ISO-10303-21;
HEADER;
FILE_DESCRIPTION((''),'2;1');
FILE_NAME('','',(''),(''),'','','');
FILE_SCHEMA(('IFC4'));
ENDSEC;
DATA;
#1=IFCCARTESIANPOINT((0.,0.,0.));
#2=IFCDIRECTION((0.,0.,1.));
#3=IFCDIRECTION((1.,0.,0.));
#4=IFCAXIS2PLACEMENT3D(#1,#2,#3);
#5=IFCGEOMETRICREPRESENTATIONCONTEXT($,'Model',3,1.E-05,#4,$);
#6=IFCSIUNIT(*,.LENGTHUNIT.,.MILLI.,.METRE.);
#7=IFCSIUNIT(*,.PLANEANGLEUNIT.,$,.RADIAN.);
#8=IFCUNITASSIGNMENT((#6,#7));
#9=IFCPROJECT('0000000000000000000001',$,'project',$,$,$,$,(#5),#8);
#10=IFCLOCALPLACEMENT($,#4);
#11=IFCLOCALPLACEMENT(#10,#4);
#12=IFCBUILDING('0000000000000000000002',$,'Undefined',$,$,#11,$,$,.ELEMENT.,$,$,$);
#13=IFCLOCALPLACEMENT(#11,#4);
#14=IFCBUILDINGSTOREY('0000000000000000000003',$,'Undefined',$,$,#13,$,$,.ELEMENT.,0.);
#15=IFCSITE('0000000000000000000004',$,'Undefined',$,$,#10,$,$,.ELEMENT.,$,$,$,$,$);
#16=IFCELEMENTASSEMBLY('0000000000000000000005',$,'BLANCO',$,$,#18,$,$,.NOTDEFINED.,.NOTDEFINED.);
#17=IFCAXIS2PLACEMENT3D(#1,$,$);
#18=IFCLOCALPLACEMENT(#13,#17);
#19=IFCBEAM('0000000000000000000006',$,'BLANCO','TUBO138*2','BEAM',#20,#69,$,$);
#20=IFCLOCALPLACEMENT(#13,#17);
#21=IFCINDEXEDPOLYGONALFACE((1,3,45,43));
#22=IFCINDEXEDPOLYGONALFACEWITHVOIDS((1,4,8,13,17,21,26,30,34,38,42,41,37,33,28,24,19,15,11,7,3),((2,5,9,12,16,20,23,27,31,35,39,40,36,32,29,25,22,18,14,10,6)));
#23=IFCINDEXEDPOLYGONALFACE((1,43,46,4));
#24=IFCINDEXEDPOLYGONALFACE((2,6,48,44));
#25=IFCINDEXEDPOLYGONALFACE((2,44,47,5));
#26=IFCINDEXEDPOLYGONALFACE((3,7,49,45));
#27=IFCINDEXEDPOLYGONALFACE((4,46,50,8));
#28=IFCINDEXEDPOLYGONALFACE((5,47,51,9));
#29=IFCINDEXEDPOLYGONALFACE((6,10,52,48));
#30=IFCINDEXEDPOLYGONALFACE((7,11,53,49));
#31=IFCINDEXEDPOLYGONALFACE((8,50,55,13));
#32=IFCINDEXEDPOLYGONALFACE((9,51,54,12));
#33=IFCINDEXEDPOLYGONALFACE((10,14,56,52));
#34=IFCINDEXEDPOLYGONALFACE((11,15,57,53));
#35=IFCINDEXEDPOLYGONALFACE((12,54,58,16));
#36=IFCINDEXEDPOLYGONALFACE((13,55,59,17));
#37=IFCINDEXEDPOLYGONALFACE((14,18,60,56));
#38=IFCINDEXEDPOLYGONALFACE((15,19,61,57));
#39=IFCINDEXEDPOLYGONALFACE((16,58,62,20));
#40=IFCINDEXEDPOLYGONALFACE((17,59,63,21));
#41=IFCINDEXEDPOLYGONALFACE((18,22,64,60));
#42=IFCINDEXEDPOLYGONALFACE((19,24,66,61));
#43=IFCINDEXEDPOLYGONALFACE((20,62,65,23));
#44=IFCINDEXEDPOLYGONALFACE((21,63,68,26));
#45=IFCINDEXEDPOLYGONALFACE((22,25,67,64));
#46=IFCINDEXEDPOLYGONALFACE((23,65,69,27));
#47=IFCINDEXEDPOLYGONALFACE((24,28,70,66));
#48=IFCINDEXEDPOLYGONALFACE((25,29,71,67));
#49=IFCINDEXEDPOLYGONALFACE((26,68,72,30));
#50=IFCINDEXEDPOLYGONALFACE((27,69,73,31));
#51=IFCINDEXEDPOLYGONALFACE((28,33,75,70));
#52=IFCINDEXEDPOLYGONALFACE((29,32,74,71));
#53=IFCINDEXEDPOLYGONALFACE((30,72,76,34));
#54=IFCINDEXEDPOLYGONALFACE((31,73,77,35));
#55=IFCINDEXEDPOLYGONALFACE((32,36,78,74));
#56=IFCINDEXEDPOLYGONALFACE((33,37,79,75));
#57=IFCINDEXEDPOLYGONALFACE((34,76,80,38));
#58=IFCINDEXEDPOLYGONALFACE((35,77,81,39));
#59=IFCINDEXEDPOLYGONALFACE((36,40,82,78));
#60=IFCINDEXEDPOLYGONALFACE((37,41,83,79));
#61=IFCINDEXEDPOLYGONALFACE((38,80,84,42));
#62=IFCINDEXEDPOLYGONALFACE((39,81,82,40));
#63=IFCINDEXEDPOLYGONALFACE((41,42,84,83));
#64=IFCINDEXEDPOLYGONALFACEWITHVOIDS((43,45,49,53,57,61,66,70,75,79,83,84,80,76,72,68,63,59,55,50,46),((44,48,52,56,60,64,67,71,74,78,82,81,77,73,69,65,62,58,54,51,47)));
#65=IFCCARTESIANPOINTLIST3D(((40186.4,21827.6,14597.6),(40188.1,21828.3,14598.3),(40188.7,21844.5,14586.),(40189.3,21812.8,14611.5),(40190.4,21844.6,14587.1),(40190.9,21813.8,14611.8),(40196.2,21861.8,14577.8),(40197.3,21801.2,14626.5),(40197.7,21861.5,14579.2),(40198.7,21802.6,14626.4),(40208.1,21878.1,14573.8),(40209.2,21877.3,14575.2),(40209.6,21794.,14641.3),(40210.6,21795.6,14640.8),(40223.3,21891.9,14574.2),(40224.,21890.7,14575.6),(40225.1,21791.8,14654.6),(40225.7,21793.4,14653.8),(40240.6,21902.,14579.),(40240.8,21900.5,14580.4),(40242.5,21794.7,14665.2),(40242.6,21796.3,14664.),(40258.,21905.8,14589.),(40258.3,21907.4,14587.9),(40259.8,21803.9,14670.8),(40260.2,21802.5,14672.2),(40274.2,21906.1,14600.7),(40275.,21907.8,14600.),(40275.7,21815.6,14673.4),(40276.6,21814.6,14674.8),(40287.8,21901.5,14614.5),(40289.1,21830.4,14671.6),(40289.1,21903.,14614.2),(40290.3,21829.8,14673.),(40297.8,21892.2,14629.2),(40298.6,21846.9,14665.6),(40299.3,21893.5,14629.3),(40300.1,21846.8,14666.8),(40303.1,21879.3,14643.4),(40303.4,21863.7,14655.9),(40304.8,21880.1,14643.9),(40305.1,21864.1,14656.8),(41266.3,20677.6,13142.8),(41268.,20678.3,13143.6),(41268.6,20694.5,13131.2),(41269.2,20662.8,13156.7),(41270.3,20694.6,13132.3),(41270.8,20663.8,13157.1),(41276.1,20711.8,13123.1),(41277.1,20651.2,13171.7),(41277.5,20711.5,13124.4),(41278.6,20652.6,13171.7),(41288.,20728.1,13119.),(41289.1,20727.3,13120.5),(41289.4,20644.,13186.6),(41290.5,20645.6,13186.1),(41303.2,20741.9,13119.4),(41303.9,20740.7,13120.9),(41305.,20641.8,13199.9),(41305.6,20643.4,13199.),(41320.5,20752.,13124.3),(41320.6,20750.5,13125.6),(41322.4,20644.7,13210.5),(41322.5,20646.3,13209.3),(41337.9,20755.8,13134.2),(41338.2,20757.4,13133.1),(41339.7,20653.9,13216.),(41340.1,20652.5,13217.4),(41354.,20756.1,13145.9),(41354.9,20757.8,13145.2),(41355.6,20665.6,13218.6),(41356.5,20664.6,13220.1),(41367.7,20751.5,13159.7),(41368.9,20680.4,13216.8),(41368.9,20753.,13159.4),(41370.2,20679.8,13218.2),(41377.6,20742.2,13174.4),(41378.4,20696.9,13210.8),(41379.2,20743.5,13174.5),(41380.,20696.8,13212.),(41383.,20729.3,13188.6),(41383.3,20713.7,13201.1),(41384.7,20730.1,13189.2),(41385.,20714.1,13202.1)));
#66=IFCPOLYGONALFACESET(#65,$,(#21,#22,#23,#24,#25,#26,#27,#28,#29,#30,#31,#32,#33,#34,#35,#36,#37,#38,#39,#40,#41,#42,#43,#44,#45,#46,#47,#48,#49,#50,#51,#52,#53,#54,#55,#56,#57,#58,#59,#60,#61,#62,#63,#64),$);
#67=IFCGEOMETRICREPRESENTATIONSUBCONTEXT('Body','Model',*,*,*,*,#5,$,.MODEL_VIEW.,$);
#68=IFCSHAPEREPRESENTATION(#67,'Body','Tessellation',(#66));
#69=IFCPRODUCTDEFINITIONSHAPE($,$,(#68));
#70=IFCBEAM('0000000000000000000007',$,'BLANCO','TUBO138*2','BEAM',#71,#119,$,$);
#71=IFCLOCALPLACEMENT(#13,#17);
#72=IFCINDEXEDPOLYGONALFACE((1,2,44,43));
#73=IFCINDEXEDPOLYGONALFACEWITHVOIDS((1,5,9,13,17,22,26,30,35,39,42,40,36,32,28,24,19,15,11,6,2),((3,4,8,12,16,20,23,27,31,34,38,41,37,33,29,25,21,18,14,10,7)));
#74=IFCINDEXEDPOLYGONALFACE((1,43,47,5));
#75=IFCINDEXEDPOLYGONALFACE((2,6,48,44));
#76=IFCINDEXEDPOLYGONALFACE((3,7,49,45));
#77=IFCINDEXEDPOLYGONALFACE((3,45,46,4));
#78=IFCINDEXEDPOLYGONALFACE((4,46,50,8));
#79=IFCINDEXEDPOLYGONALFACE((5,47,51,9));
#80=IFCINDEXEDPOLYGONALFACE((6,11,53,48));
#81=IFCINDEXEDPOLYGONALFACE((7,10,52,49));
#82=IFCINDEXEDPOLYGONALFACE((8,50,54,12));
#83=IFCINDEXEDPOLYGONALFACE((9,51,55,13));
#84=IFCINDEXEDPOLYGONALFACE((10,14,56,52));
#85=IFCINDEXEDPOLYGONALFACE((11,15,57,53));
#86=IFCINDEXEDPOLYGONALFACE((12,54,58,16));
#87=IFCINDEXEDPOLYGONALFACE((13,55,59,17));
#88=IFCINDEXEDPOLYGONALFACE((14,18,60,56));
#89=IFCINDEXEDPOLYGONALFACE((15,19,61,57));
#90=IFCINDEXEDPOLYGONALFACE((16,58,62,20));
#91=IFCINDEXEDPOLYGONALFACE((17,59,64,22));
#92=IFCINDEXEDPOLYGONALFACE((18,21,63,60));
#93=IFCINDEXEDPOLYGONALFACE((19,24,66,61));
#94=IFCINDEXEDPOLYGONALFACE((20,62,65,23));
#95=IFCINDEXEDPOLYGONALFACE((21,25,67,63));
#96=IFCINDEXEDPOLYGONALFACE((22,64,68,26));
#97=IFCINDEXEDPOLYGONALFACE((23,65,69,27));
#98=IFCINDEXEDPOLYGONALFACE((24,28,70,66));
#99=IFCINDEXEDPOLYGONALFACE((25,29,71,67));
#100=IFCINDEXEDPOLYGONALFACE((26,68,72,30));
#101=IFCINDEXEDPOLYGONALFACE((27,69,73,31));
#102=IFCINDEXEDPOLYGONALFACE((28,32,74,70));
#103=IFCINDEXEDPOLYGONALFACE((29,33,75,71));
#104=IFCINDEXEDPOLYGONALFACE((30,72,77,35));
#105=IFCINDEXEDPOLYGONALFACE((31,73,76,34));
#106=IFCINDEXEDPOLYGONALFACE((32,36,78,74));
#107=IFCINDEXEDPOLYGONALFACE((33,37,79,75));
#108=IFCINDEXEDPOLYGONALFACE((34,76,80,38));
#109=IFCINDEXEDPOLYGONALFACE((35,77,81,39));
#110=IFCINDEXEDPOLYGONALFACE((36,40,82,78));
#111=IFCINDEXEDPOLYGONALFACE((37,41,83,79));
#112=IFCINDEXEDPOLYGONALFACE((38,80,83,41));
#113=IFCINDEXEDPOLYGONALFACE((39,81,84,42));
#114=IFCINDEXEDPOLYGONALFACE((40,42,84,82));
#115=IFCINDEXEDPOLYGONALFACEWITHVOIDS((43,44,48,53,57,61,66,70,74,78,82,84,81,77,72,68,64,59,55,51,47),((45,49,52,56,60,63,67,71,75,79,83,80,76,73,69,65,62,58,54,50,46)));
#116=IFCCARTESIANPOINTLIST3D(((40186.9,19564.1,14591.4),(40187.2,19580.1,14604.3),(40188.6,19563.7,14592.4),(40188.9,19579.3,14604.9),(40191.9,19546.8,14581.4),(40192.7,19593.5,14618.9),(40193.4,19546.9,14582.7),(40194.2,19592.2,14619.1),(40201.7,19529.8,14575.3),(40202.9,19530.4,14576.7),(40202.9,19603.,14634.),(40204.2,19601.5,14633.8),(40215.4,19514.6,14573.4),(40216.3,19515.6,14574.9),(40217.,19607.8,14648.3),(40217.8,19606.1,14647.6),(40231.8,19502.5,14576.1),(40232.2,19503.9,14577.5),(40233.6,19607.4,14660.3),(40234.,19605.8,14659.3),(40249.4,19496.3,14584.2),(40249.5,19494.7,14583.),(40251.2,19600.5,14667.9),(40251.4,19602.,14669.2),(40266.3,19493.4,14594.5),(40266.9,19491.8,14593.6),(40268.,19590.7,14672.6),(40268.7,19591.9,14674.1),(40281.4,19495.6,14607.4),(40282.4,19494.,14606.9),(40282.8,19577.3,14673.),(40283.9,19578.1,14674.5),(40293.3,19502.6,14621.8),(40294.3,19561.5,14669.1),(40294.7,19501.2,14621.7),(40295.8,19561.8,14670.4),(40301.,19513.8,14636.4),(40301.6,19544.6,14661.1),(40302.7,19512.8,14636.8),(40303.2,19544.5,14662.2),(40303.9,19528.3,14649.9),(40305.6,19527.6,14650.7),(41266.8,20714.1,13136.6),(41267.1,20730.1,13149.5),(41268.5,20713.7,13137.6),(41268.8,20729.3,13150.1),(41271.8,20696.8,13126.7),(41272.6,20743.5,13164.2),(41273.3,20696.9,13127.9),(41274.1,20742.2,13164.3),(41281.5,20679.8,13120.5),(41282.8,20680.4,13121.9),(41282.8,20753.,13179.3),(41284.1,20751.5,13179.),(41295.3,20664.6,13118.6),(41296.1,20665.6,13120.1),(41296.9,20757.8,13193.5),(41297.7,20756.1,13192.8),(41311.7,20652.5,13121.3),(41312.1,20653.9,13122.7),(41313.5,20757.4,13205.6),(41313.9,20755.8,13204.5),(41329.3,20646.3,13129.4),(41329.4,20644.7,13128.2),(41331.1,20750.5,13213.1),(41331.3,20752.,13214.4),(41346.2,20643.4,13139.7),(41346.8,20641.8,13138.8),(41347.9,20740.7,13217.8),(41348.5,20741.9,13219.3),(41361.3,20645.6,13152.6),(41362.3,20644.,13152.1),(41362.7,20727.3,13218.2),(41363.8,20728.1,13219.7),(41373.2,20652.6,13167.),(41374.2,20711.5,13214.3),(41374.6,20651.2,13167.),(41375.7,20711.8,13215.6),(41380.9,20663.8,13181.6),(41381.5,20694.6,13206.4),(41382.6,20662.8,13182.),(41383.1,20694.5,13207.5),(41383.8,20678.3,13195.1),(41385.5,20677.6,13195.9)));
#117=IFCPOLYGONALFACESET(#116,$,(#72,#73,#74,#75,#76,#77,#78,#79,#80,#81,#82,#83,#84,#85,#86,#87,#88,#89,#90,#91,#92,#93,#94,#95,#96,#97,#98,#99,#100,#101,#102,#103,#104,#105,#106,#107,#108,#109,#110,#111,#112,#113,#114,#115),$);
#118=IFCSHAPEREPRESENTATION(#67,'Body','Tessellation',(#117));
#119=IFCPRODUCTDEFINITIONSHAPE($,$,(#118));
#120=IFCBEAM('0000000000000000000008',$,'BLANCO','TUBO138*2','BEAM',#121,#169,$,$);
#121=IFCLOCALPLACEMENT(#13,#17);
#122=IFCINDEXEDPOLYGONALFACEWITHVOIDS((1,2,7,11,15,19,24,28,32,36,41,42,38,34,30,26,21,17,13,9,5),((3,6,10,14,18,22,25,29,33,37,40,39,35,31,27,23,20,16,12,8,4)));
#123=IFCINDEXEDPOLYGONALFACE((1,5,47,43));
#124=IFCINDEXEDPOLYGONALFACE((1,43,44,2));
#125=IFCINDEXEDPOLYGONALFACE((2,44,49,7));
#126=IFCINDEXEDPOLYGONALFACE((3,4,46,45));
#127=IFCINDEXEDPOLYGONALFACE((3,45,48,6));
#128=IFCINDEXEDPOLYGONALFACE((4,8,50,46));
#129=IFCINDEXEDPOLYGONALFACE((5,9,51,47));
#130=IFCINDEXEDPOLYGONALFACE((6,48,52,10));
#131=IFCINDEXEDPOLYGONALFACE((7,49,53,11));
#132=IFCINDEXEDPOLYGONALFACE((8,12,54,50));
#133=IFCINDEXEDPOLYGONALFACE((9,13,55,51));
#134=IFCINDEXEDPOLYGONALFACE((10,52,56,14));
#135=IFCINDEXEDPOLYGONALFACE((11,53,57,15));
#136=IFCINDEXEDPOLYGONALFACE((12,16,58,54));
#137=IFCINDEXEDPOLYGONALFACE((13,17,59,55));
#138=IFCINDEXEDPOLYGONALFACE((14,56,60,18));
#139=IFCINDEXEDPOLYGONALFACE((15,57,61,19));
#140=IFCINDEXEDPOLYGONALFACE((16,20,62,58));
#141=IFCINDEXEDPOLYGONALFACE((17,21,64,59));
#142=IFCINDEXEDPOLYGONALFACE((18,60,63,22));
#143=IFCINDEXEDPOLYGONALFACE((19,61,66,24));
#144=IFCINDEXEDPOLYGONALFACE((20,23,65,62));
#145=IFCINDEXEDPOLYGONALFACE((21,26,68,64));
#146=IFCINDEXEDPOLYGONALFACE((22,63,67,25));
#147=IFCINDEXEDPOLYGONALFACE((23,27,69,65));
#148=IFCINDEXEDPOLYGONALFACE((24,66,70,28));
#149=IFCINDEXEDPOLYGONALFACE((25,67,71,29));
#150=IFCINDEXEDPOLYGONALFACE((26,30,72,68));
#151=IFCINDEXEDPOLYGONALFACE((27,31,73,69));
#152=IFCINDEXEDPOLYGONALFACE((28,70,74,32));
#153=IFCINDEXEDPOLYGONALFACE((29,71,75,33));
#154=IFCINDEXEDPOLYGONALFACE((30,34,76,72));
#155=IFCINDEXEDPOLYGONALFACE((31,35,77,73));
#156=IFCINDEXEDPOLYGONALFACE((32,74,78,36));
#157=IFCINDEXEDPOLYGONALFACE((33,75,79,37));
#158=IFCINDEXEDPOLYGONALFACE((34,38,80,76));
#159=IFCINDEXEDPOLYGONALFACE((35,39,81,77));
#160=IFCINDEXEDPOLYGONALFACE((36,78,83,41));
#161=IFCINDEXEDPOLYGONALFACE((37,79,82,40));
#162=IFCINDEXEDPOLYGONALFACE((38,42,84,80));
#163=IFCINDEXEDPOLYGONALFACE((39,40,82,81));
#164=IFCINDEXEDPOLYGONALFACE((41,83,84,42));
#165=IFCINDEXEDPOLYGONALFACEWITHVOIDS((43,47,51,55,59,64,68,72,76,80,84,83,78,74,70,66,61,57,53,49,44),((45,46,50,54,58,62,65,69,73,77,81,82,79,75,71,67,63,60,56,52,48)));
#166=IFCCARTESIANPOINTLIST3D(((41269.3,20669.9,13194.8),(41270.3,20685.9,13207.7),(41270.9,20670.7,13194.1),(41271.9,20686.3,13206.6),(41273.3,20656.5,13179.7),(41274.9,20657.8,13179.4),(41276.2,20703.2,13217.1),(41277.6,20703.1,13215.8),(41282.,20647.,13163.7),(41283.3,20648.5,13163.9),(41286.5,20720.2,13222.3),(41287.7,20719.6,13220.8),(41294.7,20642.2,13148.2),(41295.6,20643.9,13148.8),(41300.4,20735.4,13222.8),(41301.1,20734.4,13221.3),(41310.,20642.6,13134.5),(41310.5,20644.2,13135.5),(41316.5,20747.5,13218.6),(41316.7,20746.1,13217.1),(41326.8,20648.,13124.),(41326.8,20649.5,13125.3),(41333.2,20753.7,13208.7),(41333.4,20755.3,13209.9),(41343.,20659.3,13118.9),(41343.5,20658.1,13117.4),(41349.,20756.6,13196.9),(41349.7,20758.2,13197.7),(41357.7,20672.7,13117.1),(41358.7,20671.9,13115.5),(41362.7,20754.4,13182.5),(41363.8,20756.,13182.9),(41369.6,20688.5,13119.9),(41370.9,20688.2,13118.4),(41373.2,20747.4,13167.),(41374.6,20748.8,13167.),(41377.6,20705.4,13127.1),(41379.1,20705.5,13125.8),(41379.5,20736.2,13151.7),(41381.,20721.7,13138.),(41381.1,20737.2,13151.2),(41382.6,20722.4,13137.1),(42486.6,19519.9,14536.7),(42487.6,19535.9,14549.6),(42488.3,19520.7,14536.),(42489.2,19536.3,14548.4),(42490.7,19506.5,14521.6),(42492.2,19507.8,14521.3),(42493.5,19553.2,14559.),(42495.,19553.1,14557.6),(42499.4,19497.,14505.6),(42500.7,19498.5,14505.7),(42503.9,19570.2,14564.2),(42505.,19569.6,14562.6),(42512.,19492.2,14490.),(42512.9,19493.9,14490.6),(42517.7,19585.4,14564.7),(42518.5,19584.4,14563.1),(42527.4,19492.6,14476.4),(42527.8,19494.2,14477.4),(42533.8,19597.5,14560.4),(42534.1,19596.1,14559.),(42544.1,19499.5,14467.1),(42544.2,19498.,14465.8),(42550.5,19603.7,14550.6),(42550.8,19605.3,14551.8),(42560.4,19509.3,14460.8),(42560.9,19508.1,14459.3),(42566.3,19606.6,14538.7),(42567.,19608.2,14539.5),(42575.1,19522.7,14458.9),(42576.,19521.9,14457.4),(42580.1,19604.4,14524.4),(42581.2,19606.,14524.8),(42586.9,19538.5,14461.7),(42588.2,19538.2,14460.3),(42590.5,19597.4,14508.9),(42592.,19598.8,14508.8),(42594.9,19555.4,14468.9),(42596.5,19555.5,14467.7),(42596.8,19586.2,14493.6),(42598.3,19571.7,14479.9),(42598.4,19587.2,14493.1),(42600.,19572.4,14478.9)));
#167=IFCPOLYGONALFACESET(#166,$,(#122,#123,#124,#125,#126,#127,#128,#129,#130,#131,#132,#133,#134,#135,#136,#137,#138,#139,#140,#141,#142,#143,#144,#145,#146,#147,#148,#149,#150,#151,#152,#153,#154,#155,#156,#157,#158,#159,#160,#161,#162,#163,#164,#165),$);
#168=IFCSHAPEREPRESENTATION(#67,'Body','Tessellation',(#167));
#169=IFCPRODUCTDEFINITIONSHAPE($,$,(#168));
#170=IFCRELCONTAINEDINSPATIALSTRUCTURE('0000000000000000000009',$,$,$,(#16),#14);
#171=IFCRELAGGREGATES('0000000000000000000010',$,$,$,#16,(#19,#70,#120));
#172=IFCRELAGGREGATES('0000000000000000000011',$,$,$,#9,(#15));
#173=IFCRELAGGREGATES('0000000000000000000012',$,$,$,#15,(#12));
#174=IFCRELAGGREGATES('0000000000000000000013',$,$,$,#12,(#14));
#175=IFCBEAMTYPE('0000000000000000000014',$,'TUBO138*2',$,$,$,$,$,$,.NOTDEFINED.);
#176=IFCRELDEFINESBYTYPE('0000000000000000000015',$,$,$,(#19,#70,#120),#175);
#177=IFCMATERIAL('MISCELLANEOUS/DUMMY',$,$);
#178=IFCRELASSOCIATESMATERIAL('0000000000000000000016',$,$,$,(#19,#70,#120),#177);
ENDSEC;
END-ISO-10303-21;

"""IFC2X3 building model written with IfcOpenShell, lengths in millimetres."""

from ifc_helpers import new_model, si_unit, frame, origin_with_axes, origin_2d_with_axis, place, context, subcontext, project, spatial, hollow_circle, extrude, material, type_object, element, aggregate, save


model = new_model("IFC2X3")

# Units and contexts
model_context = context("Model", 3, precision=1e-05, world=origin_with_axes())
body_context = subcontext(model_context, "Body", "Model", "MODEL_VIEW")
ifc_project = project(units=[si_unit("LENGTHUNIT", "METRE", prefix="MILLI"), si_unit("PLANEANGLEUNIT", "RADIAN")], contexts=[model_context])

# Site, building, storey
site_placement = place(None, origin_with_axes())
site = spatial("IfcSite", under=ifc_project, at=site_placement, Name="Undefined", CompositionType="ELEMENT")
building_placement = place(site_placement, origin_with_axes())
building = spatial("IfcBuilding", under=site, at=building_placement, Name="Undefined", CompositionType="ELEMENT")
storey_placement = place(building_placement, origin_with_axes())
storey = spatial("IfcBuildingStorey", under=building, at=storey_placement, Name="Undefined", CompositionType="ELEMENT", Elevation=0.0)

# Element assembly, beams
assembly_placement = place(storey_placement, origin_with_axes())
assembly = element("IfcElementAssembly", 1, at=assembly_placement, inside=storey, Name="BLANCO", AssemblyPlace="NOTDEFINED", PredefinedType="NOTDEFINED")
ifc_material = material(Name="MISCELLANEOUS/DUMMY")
beam_type = type_object("IfcBeamType", Name="TUBO138*2", PredefinedType="NOTDEFINED")
beam_1_placement = place(assembly_placement, frame((41325.9, 20700.0, 13169.4), z_axis=(-0.497966, 0.461316, -0.734314), x_axis=(-0.503224, 0.535899, 0.677922)))
beam_1 = element("IfcBeam", 2, at=beam_1_placement, type_object=beam_type, material=ifc_material, Name="BLANCO", Description="TUBO138*2", ObjectType="BEAM", context=body_context, shape_type="SweptSolid", body=[
    extrude(hollow_circle(Radius=69.0, WallThickness=2.0, at=origin_2d_with_axis()), frame((2145.9, 0.0, 0.0), z_axis=(-1.0, 0.0, 0.0), x_axis=(0.0, -1.0, 0.0)), (0.0, 0.0, 1.0), 2145.9),
])
beam_2_placement = place(assembly_placement, frame((41325.9, 20700.0, 13169.4), z_axis=(-0.497966, -0.461316, -0.734314), x_axis=(-0.503224, -0.535899, 0.677922)))
beam_2 = element("IfcBeam", 3, at=beam_2_placement, type_object=beam_type, material=ifc_material, Name="BLANCO", Description="TUBO138*2", ObjectType="BEAM", context=body_context, shape_type="SweptSolid", body=[
    extrude(hollow_circle(Radius=69.0, WallThickness=2.0, at=origin_2d_with_axis()), frame((2145.9, 0.0, 0.0), z_axis=(-1.0, 0.0, 0.0), x_axis=(0.0, -1.0, 0.0)), (0.0, 0.0, 1.0), 2145.9),
])
beam_3_placement = place(assembly_placement, frame((41325.9, 20700.0, 13169.4), z_axis=(0.423552, -0.461316, -0.77961), x_axis=(0.567282, -0.535899, 0.625303)))
beam_3 = element("IfcBeam", 4, at=beam_3_placement, type_object=beam_type, material=ifc_material, Name="BLANCO", Description="TUBO138*2", ObjectType="BEAM", context=body_context, shape_type="SweptSolid", body=[
    extrude(hollow_circle(Radius=69.0, WallThickness=2.0, at=origin_2d_with_axis()), frame((2145.9, 0.0, 0.0), z_axis=(-1.0, 0.0, 0.0), x_axis=(0.0, -1.0, 0.0)), (0.0, 0.0, 1.0), 2145.9),
])
aggregate(assembly, [beam_1, beam_2, beam_3])

save(model, "model.ifc")
